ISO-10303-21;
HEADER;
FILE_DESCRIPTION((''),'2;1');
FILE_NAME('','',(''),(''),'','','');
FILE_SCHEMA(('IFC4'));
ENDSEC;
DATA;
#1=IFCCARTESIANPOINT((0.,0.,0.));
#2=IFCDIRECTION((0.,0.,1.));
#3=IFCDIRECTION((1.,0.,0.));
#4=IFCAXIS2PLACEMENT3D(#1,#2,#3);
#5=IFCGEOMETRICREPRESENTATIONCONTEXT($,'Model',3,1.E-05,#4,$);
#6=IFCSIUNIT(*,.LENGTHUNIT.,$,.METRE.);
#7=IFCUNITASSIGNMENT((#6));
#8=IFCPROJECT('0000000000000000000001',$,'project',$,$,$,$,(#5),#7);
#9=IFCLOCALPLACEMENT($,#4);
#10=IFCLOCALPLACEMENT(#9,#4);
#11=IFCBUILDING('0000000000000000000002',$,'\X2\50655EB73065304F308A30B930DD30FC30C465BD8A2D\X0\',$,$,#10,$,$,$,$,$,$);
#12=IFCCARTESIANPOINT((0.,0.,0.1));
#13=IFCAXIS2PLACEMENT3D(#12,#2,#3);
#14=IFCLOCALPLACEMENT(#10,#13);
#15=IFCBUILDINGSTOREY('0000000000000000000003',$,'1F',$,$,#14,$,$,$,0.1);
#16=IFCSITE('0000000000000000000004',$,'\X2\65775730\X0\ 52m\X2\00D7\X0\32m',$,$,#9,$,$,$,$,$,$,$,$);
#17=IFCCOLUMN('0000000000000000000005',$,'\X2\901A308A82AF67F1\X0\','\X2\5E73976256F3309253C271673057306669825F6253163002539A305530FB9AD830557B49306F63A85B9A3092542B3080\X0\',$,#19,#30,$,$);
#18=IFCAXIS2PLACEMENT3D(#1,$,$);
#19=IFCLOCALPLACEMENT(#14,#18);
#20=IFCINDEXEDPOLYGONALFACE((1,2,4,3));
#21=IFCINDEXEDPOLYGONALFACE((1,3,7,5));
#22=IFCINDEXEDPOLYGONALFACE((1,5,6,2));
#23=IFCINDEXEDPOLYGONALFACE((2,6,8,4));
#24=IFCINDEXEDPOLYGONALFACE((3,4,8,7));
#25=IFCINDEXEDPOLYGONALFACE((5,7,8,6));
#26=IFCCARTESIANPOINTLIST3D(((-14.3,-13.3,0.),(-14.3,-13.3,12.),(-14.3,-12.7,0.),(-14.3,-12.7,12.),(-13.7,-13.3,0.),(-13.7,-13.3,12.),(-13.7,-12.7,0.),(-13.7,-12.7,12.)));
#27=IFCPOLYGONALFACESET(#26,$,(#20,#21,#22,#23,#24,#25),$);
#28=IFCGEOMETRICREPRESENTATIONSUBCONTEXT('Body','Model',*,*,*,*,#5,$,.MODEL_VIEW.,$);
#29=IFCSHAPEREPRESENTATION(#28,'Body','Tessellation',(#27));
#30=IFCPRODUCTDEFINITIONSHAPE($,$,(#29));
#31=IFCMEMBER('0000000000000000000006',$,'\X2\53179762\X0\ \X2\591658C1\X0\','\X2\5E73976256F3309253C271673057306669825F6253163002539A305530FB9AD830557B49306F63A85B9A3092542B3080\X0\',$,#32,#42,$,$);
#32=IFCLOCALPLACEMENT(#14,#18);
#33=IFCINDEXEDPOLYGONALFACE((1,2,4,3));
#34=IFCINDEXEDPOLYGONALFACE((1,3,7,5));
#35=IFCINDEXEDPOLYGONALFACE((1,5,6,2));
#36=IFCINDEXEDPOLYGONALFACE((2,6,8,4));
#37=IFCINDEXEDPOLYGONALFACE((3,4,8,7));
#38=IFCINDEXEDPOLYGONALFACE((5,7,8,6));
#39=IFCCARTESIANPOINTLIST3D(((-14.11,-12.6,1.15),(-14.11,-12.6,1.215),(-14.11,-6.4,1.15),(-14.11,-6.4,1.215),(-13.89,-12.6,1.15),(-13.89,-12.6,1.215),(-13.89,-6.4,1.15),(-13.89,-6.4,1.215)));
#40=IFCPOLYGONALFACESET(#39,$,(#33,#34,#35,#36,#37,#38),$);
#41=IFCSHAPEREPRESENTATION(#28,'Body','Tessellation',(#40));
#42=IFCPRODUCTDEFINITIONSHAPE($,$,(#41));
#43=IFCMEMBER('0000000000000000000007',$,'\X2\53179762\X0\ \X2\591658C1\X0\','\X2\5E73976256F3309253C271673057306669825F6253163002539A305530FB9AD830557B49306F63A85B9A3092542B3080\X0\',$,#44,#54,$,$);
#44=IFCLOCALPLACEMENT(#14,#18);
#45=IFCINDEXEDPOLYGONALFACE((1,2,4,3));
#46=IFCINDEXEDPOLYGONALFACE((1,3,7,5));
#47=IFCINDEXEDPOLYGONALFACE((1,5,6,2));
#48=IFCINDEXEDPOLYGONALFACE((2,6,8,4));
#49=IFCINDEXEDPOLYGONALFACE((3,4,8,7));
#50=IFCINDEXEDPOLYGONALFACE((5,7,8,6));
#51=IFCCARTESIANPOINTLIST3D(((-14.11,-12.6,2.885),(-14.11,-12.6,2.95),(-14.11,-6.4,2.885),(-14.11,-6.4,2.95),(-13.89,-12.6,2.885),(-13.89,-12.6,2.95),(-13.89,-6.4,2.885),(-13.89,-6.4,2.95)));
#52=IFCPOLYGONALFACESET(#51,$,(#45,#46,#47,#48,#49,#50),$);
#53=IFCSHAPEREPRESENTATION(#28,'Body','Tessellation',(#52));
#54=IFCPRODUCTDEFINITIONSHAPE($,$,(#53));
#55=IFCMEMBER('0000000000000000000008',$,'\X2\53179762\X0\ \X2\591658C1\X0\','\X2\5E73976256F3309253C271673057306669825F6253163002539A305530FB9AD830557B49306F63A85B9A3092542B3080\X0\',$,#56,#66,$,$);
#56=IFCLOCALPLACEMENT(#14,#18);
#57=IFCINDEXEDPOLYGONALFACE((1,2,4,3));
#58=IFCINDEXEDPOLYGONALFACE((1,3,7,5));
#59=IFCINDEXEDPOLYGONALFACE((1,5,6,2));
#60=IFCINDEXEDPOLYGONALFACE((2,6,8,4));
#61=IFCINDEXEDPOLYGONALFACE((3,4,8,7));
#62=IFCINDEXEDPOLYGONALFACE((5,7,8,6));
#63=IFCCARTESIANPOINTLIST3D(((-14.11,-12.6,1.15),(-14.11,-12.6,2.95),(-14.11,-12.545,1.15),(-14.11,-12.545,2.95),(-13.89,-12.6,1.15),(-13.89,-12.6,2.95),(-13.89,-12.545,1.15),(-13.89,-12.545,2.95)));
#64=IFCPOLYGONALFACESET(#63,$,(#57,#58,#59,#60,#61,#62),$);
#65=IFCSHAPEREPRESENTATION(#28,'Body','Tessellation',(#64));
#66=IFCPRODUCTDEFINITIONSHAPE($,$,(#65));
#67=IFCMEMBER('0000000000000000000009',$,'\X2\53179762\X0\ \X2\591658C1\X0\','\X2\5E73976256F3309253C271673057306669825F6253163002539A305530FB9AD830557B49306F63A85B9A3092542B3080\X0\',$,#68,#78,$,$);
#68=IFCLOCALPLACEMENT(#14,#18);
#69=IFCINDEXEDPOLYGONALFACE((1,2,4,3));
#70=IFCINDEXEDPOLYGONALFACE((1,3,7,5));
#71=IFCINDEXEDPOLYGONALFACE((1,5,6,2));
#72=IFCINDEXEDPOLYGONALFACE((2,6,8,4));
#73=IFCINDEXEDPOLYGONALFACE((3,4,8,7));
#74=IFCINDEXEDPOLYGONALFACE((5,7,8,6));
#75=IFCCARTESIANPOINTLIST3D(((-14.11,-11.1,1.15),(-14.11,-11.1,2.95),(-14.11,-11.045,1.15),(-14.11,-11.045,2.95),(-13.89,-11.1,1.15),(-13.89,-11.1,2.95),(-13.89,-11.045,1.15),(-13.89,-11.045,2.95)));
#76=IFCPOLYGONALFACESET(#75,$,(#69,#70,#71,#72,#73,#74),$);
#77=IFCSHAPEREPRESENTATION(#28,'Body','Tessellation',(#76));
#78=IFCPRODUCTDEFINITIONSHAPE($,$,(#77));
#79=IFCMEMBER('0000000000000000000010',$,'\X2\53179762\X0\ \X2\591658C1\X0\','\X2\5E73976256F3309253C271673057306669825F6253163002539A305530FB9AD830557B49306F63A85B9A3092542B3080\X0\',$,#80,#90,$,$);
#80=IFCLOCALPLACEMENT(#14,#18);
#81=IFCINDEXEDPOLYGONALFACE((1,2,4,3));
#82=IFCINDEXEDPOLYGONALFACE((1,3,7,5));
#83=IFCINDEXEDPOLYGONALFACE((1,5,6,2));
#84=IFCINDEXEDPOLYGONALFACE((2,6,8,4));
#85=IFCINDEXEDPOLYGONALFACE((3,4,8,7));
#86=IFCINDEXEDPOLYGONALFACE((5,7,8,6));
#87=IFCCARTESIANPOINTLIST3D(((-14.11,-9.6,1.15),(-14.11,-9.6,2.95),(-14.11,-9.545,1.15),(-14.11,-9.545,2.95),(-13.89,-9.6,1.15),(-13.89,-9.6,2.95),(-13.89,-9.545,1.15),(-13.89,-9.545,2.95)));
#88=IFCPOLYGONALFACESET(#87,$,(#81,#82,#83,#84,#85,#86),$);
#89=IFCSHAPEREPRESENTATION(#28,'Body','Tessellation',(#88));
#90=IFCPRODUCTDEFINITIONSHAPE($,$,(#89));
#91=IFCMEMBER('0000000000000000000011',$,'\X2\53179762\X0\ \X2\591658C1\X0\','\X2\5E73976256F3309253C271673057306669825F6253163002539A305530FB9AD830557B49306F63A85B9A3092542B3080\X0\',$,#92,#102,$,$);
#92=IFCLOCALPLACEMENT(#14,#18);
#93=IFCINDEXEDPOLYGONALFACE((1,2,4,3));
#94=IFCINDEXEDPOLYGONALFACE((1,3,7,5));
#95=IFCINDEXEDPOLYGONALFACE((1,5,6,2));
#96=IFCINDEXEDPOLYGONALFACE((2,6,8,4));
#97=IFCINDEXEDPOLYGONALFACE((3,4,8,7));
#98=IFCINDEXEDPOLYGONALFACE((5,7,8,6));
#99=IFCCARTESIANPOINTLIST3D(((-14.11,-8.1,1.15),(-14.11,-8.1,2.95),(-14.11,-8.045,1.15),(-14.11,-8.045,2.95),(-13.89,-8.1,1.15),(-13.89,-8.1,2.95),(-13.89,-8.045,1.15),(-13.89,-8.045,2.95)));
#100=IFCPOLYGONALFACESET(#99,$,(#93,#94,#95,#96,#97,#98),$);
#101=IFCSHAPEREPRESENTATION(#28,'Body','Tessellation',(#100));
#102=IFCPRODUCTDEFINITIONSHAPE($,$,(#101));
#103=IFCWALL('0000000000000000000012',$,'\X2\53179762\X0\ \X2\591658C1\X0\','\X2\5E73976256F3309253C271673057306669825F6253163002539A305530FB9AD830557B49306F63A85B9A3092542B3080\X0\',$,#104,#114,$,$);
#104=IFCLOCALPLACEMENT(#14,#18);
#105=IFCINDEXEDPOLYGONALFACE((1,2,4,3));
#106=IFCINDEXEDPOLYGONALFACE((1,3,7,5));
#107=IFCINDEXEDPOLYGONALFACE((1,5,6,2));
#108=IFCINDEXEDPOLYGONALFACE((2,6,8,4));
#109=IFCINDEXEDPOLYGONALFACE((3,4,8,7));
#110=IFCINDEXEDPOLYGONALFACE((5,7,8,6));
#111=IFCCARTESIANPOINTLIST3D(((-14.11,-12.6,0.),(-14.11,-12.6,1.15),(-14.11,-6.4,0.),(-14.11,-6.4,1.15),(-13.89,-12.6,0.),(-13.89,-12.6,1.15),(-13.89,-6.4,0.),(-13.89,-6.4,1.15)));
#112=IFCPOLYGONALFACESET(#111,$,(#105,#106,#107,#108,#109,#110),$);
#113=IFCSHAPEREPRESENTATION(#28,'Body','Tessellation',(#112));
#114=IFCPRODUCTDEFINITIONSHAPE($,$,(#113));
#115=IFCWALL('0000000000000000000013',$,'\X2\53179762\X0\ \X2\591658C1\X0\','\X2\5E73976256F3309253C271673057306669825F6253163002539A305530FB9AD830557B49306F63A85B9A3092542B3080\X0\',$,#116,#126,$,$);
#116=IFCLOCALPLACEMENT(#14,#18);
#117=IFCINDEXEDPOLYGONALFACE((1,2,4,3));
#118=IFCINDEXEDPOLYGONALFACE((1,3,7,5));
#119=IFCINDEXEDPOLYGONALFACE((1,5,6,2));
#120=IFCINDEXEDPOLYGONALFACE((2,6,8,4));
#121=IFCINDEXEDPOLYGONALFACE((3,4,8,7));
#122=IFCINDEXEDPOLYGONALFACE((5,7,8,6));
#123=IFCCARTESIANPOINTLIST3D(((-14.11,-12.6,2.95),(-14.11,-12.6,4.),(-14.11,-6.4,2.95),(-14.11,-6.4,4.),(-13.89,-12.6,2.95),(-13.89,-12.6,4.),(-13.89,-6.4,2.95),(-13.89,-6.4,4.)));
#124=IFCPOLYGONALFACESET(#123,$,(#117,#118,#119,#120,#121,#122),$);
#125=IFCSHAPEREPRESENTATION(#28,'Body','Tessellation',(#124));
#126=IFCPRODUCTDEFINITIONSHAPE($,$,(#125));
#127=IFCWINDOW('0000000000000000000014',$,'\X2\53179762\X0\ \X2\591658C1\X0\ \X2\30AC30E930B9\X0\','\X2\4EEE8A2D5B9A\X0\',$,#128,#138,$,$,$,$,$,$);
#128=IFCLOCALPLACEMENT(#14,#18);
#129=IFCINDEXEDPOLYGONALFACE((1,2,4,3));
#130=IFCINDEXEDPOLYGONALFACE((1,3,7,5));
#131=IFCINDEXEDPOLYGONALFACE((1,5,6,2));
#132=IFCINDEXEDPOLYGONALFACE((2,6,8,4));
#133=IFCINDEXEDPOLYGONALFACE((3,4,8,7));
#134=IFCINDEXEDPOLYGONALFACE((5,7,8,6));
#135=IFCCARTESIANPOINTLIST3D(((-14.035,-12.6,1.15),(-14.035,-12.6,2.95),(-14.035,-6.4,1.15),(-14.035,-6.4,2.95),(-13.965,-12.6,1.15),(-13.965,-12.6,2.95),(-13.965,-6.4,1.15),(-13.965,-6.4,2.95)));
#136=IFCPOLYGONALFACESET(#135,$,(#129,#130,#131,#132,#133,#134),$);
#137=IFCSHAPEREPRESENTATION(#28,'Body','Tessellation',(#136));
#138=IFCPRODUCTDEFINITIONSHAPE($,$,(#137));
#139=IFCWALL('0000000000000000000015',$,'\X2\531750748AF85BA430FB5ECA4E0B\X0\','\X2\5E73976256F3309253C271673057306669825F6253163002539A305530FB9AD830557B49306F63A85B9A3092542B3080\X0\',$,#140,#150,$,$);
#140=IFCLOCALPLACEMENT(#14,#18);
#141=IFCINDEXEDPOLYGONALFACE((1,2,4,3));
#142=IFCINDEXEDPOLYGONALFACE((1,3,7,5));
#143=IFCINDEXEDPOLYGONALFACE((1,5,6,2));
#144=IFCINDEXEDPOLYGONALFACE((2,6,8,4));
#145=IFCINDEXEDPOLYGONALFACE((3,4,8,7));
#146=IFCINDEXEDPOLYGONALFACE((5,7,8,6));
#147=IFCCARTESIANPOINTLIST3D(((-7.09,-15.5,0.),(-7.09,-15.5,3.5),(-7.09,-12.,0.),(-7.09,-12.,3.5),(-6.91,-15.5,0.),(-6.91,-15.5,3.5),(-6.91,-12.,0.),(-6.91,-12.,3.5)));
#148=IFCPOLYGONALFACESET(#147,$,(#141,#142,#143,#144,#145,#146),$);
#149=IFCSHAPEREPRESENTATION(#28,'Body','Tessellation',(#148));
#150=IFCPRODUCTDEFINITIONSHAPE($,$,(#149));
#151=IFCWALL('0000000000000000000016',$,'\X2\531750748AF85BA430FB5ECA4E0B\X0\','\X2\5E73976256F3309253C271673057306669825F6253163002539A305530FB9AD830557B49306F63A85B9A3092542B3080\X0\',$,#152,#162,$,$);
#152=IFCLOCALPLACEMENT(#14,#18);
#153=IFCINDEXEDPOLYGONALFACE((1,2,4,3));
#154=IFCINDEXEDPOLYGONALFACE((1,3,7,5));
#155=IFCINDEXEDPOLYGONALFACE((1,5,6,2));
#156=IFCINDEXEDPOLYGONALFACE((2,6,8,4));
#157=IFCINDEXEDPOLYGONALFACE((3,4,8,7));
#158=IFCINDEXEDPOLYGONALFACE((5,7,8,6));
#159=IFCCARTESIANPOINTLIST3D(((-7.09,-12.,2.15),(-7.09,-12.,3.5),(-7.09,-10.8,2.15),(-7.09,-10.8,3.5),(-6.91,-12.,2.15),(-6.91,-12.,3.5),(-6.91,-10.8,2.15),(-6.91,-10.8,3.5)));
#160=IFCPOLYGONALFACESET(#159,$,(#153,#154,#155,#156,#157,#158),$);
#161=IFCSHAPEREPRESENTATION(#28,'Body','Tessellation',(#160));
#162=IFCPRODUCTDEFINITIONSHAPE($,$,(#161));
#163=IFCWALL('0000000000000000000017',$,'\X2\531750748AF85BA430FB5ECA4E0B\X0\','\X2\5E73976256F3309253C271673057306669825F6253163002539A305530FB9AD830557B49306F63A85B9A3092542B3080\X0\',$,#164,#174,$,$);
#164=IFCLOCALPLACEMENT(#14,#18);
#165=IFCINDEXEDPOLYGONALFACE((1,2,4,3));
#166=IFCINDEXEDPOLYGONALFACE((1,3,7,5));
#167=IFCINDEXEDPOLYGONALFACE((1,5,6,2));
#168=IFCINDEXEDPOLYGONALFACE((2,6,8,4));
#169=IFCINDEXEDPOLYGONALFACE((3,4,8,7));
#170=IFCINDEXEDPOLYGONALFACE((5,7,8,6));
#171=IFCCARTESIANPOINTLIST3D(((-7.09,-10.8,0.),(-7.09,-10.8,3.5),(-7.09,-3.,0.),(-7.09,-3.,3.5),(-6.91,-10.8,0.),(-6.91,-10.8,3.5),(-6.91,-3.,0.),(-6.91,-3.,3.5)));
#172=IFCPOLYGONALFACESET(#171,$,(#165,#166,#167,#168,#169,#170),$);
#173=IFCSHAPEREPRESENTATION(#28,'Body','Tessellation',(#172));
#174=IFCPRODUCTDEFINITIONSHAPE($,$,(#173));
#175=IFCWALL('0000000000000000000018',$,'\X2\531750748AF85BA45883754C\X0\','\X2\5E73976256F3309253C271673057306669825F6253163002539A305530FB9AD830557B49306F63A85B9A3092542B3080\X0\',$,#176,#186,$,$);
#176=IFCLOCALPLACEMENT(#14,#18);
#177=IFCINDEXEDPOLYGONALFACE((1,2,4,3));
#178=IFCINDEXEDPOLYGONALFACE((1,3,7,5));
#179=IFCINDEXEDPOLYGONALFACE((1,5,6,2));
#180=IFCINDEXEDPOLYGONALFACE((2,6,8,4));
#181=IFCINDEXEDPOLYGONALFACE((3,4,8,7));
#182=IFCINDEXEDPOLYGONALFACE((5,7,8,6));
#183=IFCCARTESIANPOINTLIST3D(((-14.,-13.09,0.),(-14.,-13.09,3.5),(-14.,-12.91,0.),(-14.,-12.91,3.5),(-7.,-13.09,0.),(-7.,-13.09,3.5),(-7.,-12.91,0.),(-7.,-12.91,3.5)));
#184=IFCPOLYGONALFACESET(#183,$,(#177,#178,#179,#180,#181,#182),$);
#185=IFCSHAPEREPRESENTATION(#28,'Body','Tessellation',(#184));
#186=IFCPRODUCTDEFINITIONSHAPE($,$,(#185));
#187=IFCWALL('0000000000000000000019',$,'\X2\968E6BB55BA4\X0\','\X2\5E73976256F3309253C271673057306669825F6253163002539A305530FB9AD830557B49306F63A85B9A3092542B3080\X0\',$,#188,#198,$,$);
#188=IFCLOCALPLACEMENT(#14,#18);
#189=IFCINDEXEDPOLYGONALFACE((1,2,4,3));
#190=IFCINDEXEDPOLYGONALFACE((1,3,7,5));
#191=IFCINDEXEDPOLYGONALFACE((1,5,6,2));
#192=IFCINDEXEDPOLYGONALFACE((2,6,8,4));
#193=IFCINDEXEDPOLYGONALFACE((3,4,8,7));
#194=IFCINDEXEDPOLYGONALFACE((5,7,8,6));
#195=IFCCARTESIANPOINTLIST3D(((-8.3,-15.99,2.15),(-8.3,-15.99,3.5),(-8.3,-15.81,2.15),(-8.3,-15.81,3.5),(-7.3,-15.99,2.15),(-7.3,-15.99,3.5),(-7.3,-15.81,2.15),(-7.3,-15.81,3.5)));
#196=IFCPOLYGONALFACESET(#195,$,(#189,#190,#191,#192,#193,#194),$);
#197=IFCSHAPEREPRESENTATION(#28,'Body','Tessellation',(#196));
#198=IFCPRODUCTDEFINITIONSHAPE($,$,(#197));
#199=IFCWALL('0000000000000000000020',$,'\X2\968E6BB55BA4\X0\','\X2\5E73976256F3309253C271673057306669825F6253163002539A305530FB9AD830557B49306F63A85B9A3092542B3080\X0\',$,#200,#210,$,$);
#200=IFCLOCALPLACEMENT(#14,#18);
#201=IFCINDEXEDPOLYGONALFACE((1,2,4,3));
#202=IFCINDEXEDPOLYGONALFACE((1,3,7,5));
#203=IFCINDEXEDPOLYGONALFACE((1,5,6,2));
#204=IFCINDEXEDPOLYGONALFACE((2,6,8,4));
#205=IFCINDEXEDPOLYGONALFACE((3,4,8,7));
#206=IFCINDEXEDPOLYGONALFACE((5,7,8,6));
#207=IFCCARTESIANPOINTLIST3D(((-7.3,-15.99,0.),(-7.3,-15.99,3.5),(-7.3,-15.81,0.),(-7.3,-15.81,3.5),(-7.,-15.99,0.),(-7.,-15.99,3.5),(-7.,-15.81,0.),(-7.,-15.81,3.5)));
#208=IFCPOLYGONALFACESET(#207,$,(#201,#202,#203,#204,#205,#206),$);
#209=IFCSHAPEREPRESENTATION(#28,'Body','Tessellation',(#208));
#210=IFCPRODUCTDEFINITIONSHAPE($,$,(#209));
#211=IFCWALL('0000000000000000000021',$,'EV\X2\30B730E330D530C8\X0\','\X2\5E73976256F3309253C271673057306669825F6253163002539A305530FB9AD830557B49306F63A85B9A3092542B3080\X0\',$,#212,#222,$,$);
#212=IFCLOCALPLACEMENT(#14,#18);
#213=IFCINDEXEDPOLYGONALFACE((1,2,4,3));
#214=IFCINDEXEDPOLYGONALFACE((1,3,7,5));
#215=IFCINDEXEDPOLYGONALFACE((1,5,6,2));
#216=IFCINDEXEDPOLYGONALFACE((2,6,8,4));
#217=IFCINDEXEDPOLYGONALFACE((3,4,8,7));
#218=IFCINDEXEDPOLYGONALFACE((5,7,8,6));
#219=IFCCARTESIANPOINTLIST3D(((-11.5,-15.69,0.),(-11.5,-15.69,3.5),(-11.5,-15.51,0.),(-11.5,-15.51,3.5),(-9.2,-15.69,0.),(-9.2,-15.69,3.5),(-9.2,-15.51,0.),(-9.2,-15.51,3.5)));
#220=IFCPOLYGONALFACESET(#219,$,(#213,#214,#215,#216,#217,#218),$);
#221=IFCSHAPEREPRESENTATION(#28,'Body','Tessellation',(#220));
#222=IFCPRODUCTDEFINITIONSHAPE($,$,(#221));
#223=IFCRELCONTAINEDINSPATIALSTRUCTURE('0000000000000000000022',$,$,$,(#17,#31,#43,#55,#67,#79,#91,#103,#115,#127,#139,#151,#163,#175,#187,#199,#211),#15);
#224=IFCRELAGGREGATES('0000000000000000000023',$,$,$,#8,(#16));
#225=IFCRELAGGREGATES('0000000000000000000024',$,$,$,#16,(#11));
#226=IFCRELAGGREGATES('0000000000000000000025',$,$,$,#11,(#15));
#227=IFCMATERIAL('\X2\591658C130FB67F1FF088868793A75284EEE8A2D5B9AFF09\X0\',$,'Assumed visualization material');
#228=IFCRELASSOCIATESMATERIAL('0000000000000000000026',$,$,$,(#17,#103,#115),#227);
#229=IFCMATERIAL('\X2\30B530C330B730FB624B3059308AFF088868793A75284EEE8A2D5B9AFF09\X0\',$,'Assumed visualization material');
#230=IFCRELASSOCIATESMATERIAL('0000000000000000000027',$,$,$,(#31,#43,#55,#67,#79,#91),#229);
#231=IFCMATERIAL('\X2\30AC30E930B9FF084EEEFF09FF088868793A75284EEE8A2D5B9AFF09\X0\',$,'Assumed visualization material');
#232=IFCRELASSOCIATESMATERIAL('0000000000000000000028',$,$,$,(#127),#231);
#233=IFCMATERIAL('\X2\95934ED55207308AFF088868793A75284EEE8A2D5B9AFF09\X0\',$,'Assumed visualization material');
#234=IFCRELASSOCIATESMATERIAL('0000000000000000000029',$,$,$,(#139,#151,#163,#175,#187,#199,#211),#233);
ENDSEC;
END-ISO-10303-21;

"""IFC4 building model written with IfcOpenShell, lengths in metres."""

from ifc_helpers import new_model, si_unit, frame, origin_with_axes, place, context, subcontext, project, spatial, rectangle, extrude, material, element, save


model = new_model("IFC4")

# Units and contexts
model_context = context("Model", 3, precision=1e-05, world=origin_with_axes())
body_context = subcontext(model_context, "Body", "Model", "MODEL_VIEW")
ifc_project = project(units=[si_unit("LENGTHUNIT", "METRE")], contexts=[model_context])

# Site, building, storey
site_placement = place(None, origin_with_axes())
site = spatial("IfcSite", under=ifc_project, at=site_placement, Name="敷地 52m×32m")
building_placement = place(site_placement, origin_with_axes())
building = spatial("IfcBuilding", under=site, at=building_placement, Name="健康づくりスポーツ施設")
storey_placement = place(building_placement, frame((0.0, 0.0, 0.1), z_axis=(0.0, 0.0, 1.0), x_axis=(1.0, 0.0, 0.0)))
storey = spatial("IfcBuildingStorey", under=building, at=storey_placement, Name="1F", Elevation=0.1)

# Column
ifc_material_1 = material(Name="外壁・柱（表示用仮設定）", Category="Assumed visualization material")
column_placement = place(storey_placement, frame((-14.0, -13.0, 0.0), z_axis=(0.0, 0.0, 1.0), x_axis=(1.0, 0.0, 0.0)))
element("IfcColumn", 1, at=column_placement, inside=storey, material=ifc_material_1, Name="通り芯柱", Description="平面図を参照して概形化。厚さ・高さ等は推定を含む", context=body_context, shape_type="SweptSolid", body=[
    extrude(rectangle(XDim=0.6, YDim=0.6), origin_with_axes(), (0.0, 0.0, 1.0), 12.0),
])

# Members
ifc_material_2 = material(Name="サッシ・手すり（表示用仮設定）", Category="Assumed visualization material")
for number, where, z_axis, x_axis, name in (
    (2, (-14.0, -9.5, 1.15), (0.0, 0.0, 1.0), (1.0, 0.0, 0.0), "北面 外壁"),
    (3, (-14.0, -9.5, 2.885), (0.0, 0.0, 1.0), (1.0, 0.0, 0.0), "北面 外壁"),
):
    element("IfcMember", number, at=place(storey_placement, frame(where, z_axis=z_axis, x_axis=x_axis)), inside=storey, material=ifc_material_2, Name=name, Description="平面図を参照して概形化。厚さ・高さ等は推定を含む", context=body_context, shape_type="SweptSolid", body=[
        extrude(rectangle(XDim=0.22, YDim=6.2), origin_with_axes(), (0.0, 0.0, 1.0), 0.065),
    ])
for number, where, z_axis, x_axis, name in (
    (4, (-14.0, -12.5725, 1.15), (0.0, 0.0, 1.0), (1.0, 0.0, 0.0), "北面 外壁"),
    (5, (-14.0, -11.0725, 1.15), (0.0, 0.0, 1.0), (1.0, 0.0, 0.0), "北面 外壁"),
    (6, (-14.0, -9.5725, 1.15), (0.0, 0.0, 1.0), (1.0, 0.0, 0.0), "北面 外壁"),
    (7, (-14.0, -8.0725, 1.15), (0.0, 0.0, 1.0), (1.0, 0.0, 0.0), "北面 外壁"),
):
    element("IfcMember", number, at=place(storey_placement, frame(where, z_axis=z_axis, x_axis=x_axis)), inside=storey, material=ifc_material_2, Name=name, Description="平面図を参照して概形化。厚さ・高さ等は推定を含む", context=body_context, shape_type="SweptSolid", body=[
        extrude(rectangle(XDim=0.22, YDim=0.055), origin_with_axes(), (0.0, 0.0, 1.0), 1.8),
    ])

# Walls
wall_1_placement = place(storey_placement, frame((-14.0, -9.5, 0.0), z_axis=(0.0, 0.0, 1.0), x_axis=(1.0, 0.0, 0.0)))
element("IfcWall", 8, at=wall_1_placement, inside=storey, material=ifc_material_1, Name="北面 外壁", Description="平面図を参照して概形化。厚さ・高さ等は推定を含む", context=body_context, shape_type="SweptSolid", body=[
    extrude(rectangle(XDim=0.22, YDim=6.2), origin_with_axes(), (0.0, 0.0, 1.0), 1.15),
])
wall_2_placement = place(storey_placement, frame((-14.0, -9.5, 2.95), z_axis=(0.0, 0.0, 1.0), x_axis=(1.0, 0.0, 0.0)))
element("IfcWall", 9, at=wall_2_placement, inside=storey, material=ifc_material_1, Name="北面 外壁", Description="平面図を参照して概形化。厚さ・高さ等は推定を含む", context=body_context, shape_type="SweptSolid", body=[
    extrude(rectangle(XDim=0.22, YDim=6.2), origin_with_axes(), (0.0, 0.0, 1.0), 1.05),
])

# Window
ifc_material_3 = material(Name="ガラス（仮）（表示用仮設定）", Category="Assumed visualization material")
window_placement = place(storey_placement, frame((-14.0, -9.5, 1.15), z_axis=(0.0, 0.0, 1.0), x_axis=(1.0, 0.0, 0.0)))
element("IfcWindow", 10, at=window_placement, inside=storey, material=ifc_material_3, Name="北面 外壁 ガラス", Description="仮設定", context=body_context, shape_type="SweptSolid", body=[
    extrude(rectangle(XDim=0.07, YDim=6.2), origin_with_axes(), (0.0, 0.0, 1.0), 1.8),
])

# Walls
ifc_material_4 = material(Name="間仕切り（表示用仮設定）", Category="Assumed visualization material")
wall_3_placement = place(storey_placement, frame((-7.0, -13.75, 0.0), z_axis=(0.0, 0.0, 1.0), x_axis=(1.0, 0.0, 0.0)))
element("IfcWall", 11, at=wall_3_placement, inside=storey, material=ifc_material_4, Name="北側諸室・廊下", Description="平面図を参照して概形化。厚さ・高さ等は推定を含む", context=body_context, shape_type="SweptSolid", body=[
    extrude(rectangle(XDim=0.18, YDim=3.5), origin_with_axes(), (0.0, 0.0, 1.0), 3.5),
])
wall_4_placement = place(storey_placement, frame((-7.0, -11.4, 2.15), z_axis=(0.0, 0.0, 1.0), x_axis=(1.0, 0.0, 0.0)))
element("IfcWall", 12, at=wall_4_placement, inside=storey, material=ifc_material_4, Name="北側諸室・廊下", Description="平面図を参照して概形化。厚さ・高さ等は推定を含む", context=body_context, shape_type="SweptSolid", body=[
    extrude(rectangle(XDim=0.18, YDim=1.2), origin_with_axes(), (0.0, 0.0, 1.0), 1.35),
])
wall_5_placement = place(storey_placement, frame((-7.0, -6.9, 0.0), z_axis=(0.0, 0.0, 1.0), x_axis=(1.0, 0.0, 0.0)))
element("IfcWall", 13, at=wall_5_placement, inside=storey, material=ifc_material_4, Name="北側諸室・廊下", Description="平面図を参照して概形化。厚さ・高さ等は推定を含む", context=body_context, shape_type="SweptSolid", body=[
    extrude(rectangle(XDim=0.18, YDim=7.8), origin_with_axes(), (0.0, 0.0, 1.0), 3.5),
])
wall_6_placement = place(storey_placement, frame((-10.5, -13.0, 0.0), z_axis=(0.0, 0.0, 1.0), x_axis=(1.0, 0.0, 0.0)))
element("IfcWall", 14, at=wall_6_placement, inside=storey, material=ifc_material_4, Name="北側諸室境界", Description="平面図を参照して概形化。厚さ・高さ等は推定を含む", context=body_context, shape_type="SweptSolid", body=[
    extrude(rectangle(XDim=7.0, YDim=0.18), origin_with_axes(), (0.0, 0.0, 1.0), 3.5),
])
wall_7_placement = place(storey_placement, frame((-7.8, -15.9, 2.15), z_axis=(0.0, 0.0, 1.0), x_axis=(1.0, 0.0, 0.0)))
element("IfcWall", 15, at=wall_7_placement, inside=storey, material=ifc_material_4, Name="階段室", Description="平面図を参照して概形化。厚さ・高さ等は推定を含む", context=body_context, shape_type="SweptSolid", body=[
    extrude(rectangle(XDim=1.0, YDim=0.18), origin_with_axes(), (0.0, 0.0, 1.0), 1.35),
])
wall_8_placement = place(storey_placement, frame((-7.15, -15.9, 0.0), z_axis=(0.0, 0.0, 1.0), x_axis=(1.0, 0.0, 0.0)))
element("IfcWall", 16, at=wall_8_placement, inside=storey, material=ifc_material_4, Name="階段室", Description="平面図を参照して概形化。厚さ・高さ等は推定を含む", context=body_context, shape_type="SweptSolid", body=[
    extrude(rectangle(XDim=0.3, YDim=0.18), origin_with_axes(), (0.0, 0.0, 1.0), 3.5),
])
for number, where, z_axis, x_axis, name in (
    (17, (-10.35, -15.6, 0.0), (0.0, 0.0, 1.0), (1.0, 0.0, 0.0), "EVシャフト"),
):
    element("IfcWall", number, at=place(storey_placement, frame(where, z_axis=z_axis, x_axis=x_axis)), inside=storey, material=ifc_material_4, Name=name, Description="平面図を参照して概形化。厚さ・高さ等は推定を含む", context=body_context, shape_type="SweptSolid", body=[
        extrude(rectangle(XDim=2.3, YDim=0.18), origin_with_axes(), (0.0, 0.0, 1.0), 3.5),
    ])

save(model, "model.ifc")
